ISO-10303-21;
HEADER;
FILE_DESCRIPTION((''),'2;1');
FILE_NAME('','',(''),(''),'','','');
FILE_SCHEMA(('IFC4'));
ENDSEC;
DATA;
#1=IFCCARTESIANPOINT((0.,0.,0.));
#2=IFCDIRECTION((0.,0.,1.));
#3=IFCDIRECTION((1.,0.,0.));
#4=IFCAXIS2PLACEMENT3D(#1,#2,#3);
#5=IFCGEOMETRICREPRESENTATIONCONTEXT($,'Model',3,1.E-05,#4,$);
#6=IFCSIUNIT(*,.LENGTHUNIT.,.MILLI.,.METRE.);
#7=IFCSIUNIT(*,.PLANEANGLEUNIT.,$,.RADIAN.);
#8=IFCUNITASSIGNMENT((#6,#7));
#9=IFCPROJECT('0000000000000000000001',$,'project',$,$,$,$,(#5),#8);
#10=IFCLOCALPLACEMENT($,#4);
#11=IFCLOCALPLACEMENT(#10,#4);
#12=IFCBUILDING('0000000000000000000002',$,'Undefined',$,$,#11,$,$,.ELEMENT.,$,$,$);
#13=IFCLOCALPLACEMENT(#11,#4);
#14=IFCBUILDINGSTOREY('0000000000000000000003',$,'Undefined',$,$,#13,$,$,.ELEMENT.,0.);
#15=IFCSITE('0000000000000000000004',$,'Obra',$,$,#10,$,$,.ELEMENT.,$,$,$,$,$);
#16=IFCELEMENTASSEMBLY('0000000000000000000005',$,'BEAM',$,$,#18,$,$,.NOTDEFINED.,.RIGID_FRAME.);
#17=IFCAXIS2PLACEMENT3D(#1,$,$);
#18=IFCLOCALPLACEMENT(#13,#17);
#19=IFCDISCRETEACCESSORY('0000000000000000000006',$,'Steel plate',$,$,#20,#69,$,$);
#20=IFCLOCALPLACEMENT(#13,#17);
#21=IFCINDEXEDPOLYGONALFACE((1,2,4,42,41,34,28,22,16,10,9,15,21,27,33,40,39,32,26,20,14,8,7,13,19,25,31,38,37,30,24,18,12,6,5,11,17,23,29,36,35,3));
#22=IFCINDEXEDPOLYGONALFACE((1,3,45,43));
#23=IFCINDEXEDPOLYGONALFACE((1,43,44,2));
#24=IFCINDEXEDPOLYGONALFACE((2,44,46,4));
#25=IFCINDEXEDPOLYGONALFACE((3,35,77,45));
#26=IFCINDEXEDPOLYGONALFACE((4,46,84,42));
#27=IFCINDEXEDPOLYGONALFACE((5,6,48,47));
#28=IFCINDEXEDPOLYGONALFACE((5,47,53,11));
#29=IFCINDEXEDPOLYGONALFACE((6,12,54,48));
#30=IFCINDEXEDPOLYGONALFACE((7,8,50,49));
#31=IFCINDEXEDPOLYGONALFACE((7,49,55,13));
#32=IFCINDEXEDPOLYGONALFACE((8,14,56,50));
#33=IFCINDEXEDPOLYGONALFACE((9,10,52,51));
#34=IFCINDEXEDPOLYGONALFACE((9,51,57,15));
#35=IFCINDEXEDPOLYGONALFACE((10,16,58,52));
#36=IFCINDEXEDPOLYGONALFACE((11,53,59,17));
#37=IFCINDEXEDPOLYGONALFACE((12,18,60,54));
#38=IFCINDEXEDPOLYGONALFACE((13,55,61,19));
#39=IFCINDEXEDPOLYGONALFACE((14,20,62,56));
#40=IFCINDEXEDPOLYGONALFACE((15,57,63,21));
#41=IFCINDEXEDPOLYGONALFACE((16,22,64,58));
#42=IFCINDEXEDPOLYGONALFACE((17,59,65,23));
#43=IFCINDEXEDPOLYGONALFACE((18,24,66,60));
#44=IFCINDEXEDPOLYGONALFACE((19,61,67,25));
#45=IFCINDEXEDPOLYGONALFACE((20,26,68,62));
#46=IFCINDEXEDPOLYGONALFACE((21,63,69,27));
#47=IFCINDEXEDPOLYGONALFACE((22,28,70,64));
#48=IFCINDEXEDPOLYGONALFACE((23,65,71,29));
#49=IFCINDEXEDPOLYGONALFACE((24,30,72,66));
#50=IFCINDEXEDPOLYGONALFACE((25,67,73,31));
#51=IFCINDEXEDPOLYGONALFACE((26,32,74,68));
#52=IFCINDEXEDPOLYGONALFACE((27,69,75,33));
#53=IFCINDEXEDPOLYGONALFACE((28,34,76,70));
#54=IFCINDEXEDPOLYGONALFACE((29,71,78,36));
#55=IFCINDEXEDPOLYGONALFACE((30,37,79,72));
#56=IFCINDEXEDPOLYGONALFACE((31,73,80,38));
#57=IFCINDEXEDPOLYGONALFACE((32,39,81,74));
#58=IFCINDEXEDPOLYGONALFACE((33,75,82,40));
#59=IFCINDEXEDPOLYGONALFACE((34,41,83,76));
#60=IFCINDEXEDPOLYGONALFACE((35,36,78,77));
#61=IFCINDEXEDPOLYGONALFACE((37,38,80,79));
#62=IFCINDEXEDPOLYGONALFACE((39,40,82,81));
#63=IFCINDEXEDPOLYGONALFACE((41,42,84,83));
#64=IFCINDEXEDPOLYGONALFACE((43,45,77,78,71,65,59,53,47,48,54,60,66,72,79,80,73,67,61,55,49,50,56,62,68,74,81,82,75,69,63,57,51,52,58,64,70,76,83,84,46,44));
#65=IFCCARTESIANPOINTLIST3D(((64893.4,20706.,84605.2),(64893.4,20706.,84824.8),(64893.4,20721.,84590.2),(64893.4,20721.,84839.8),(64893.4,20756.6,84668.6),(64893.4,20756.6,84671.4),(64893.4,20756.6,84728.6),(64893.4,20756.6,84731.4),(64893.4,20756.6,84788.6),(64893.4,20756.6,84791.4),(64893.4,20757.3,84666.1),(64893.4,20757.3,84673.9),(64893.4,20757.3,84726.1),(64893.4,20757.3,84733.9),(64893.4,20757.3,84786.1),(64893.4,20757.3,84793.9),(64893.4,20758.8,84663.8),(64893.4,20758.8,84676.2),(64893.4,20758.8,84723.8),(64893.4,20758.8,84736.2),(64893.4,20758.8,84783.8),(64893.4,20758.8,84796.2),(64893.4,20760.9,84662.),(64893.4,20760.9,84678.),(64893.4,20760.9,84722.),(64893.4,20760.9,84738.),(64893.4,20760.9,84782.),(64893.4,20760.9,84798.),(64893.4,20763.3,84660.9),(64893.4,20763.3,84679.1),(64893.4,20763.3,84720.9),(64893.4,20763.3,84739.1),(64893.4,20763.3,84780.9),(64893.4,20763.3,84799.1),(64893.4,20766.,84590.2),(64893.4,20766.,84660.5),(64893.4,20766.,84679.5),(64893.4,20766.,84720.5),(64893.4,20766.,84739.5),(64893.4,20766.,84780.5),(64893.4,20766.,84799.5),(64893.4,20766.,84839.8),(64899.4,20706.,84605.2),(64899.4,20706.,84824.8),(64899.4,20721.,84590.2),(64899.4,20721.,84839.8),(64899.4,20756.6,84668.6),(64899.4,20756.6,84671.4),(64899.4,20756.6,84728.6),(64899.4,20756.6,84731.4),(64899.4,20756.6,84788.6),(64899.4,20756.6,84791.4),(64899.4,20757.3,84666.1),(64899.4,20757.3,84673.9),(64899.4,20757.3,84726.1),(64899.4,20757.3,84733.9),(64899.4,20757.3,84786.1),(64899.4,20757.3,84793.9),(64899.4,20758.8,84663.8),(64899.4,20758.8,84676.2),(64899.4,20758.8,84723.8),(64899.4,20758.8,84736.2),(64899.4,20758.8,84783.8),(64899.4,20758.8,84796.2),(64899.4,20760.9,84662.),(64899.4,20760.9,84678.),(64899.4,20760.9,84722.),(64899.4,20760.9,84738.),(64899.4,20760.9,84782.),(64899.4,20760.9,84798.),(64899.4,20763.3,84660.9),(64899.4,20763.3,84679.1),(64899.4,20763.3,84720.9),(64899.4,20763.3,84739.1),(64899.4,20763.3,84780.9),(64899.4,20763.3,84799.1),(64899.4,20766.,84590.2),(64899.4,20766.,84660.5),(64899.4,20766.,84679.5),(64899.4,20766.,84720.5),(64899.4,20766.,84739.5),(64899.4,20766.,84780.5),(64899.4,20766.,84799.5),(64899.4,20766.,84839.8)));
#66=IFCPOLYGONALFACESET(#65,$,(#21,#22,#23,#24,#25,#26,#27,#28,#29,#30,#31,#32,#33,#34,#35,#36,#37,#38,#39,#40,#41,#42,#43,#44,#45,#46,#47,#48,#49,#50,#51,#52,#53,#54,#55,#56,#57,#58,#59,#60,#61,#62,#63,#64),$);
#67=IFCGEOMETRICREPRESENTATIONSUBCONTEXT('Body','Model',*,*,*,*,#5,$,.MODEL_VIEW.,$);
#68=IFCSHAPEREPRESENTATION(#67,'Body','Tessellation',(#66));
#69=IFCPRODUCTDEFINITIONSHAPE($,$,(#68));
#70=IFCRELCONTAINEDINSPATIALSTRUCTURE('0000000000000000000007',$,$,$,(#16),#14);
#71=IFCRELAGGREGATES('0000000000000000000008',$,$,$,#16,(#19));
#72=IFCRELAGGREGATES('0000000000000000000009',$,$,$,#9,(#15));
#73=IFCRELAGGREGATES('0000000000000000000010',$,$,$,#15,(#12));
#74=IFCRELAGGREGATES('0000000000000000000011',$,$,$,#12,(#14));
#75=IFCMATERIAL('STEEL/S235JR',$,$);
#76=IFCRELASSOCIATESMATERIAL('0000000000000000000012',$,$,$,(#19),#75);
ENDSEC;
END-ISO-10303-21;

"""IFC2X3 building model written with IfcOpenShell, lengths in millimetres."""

from ifc_helpers import new_model, si_unit, frame, origin_with_axes, origin_2d_with_axis, place, context, subcontext, project, spatial, polyline, circle, outline, extrude, source, transform, mapped, material, element, aggregate, save


model = new_model("IFC2X3")

# Units and contexts
model_context = context("Model", 3, precision=1e-05, world=origin_with_axes())
body_context = subcontext(model_context, "Body", "Model", "MODEL_VIEW")
ifc_project = project(units=[si_unit("LENGTHUNIT", "METRE", prefix="MILLI"), si_unit("PLANEANGLEUNIT", "RADIAN")], contexts=[model_context])

# Site, building, storey
site_placement = place(None, origin_with_axes())
site = spatial("IfcSite", under=ifc_project, at=site_placement, Name="Obra", CompositionType="ELEMENT")
building_placement = place(site_placement, origin_with_axes())
building = spatial("IfcBuilding", under=site, at=building_placement, Name="Undefined", CompositionType="ELEMENT")
storey_placement = place(building_placement, origin_with_axes())
storey = spatial("IfcBuildingStorey", under=building, at=storey_placement, Name="Undefined", CompositionType="ELEMENT", Elevation=0.0)

# Shared definitions
ifc_material = material(Name="STEEL/S235JR")

# Element assembly, discrete accessory, opening
assembly_1_placement = place(storey_placement, origin_with_axes())
assembly_1 = element("IfcElementAssembly", 1, at=assembly_1_placement, inside=storey, Name="BEAM", AssemblyPlace="NOTDEFINED", PredefinedType="RIGID_FRAME")
shared_shape_1 = source(origin_with_axes(), body_context, "Body", "SweptSolid", [
    extrude(circle(Radius=9.5, at=origin_2d_with_axis()), frame((0.0, -9.2, 0.0), z_axis=(0.0, 1.0, 0.0), x_axis=(1.0, 0.0, 0.0)), (0.0, 0.0, 1.0), 6.2),
])
discrete_accessory_1_placement = place(assembly_1_placement, frame((64896.4, 20766.0, 84590.2), z_axis=(-1.0, -0.000002, 0.0), x_axis=(0.000002, -1.0, 0.0)))
discrete_accessory_1 = element("IfcDiscreteAccessory", 2, at=discrete_accessory_1_placement, material=ifc_material, Name="Steel plate", context=body_context, shape_type="SweptSolid", body=[
    extrude(outline(polyline([(0.0, 0.0), (45.0, 0.0), (60.0, 15.0), (60.0, 234.6), (45.0, 249.6), (0.0, 249.6), (0.0, 0.0)])), frame((0.0, 0.0, -3.0), z_axis=(0.0, 0.0, 1.0), x_axis=(1.0, 0.0, 0.0)), (0.0, 0.0, 1.0), 6.0),
])
opening_1_placement = place(assembly_1_placement, frame((64890.3, 20716.0, 84850.0), z_axis=(-0.000002, 1.0, 0.0), x_axis=(0.0, 0.0, -1.0)))
element("IfcOpeningElement", 3, at=opening_1_placement, cuts=discrete_accessory_1, ObjectType="Opening", context=body_context, shape_type="MappedRepresentation", body=[
    mapped(shared_shape_1, transform((60.0, 0.0, 50.0))),
    mapped(shared_shape_1, transform((120.0, 0.0, 50.0))),
    mapped(shared_shape_1, transform((180.0, 0.0, 50.0))),
])
aggregate(assembly_1, [discrete_accessory_1])

save(model, "model.ifc")
